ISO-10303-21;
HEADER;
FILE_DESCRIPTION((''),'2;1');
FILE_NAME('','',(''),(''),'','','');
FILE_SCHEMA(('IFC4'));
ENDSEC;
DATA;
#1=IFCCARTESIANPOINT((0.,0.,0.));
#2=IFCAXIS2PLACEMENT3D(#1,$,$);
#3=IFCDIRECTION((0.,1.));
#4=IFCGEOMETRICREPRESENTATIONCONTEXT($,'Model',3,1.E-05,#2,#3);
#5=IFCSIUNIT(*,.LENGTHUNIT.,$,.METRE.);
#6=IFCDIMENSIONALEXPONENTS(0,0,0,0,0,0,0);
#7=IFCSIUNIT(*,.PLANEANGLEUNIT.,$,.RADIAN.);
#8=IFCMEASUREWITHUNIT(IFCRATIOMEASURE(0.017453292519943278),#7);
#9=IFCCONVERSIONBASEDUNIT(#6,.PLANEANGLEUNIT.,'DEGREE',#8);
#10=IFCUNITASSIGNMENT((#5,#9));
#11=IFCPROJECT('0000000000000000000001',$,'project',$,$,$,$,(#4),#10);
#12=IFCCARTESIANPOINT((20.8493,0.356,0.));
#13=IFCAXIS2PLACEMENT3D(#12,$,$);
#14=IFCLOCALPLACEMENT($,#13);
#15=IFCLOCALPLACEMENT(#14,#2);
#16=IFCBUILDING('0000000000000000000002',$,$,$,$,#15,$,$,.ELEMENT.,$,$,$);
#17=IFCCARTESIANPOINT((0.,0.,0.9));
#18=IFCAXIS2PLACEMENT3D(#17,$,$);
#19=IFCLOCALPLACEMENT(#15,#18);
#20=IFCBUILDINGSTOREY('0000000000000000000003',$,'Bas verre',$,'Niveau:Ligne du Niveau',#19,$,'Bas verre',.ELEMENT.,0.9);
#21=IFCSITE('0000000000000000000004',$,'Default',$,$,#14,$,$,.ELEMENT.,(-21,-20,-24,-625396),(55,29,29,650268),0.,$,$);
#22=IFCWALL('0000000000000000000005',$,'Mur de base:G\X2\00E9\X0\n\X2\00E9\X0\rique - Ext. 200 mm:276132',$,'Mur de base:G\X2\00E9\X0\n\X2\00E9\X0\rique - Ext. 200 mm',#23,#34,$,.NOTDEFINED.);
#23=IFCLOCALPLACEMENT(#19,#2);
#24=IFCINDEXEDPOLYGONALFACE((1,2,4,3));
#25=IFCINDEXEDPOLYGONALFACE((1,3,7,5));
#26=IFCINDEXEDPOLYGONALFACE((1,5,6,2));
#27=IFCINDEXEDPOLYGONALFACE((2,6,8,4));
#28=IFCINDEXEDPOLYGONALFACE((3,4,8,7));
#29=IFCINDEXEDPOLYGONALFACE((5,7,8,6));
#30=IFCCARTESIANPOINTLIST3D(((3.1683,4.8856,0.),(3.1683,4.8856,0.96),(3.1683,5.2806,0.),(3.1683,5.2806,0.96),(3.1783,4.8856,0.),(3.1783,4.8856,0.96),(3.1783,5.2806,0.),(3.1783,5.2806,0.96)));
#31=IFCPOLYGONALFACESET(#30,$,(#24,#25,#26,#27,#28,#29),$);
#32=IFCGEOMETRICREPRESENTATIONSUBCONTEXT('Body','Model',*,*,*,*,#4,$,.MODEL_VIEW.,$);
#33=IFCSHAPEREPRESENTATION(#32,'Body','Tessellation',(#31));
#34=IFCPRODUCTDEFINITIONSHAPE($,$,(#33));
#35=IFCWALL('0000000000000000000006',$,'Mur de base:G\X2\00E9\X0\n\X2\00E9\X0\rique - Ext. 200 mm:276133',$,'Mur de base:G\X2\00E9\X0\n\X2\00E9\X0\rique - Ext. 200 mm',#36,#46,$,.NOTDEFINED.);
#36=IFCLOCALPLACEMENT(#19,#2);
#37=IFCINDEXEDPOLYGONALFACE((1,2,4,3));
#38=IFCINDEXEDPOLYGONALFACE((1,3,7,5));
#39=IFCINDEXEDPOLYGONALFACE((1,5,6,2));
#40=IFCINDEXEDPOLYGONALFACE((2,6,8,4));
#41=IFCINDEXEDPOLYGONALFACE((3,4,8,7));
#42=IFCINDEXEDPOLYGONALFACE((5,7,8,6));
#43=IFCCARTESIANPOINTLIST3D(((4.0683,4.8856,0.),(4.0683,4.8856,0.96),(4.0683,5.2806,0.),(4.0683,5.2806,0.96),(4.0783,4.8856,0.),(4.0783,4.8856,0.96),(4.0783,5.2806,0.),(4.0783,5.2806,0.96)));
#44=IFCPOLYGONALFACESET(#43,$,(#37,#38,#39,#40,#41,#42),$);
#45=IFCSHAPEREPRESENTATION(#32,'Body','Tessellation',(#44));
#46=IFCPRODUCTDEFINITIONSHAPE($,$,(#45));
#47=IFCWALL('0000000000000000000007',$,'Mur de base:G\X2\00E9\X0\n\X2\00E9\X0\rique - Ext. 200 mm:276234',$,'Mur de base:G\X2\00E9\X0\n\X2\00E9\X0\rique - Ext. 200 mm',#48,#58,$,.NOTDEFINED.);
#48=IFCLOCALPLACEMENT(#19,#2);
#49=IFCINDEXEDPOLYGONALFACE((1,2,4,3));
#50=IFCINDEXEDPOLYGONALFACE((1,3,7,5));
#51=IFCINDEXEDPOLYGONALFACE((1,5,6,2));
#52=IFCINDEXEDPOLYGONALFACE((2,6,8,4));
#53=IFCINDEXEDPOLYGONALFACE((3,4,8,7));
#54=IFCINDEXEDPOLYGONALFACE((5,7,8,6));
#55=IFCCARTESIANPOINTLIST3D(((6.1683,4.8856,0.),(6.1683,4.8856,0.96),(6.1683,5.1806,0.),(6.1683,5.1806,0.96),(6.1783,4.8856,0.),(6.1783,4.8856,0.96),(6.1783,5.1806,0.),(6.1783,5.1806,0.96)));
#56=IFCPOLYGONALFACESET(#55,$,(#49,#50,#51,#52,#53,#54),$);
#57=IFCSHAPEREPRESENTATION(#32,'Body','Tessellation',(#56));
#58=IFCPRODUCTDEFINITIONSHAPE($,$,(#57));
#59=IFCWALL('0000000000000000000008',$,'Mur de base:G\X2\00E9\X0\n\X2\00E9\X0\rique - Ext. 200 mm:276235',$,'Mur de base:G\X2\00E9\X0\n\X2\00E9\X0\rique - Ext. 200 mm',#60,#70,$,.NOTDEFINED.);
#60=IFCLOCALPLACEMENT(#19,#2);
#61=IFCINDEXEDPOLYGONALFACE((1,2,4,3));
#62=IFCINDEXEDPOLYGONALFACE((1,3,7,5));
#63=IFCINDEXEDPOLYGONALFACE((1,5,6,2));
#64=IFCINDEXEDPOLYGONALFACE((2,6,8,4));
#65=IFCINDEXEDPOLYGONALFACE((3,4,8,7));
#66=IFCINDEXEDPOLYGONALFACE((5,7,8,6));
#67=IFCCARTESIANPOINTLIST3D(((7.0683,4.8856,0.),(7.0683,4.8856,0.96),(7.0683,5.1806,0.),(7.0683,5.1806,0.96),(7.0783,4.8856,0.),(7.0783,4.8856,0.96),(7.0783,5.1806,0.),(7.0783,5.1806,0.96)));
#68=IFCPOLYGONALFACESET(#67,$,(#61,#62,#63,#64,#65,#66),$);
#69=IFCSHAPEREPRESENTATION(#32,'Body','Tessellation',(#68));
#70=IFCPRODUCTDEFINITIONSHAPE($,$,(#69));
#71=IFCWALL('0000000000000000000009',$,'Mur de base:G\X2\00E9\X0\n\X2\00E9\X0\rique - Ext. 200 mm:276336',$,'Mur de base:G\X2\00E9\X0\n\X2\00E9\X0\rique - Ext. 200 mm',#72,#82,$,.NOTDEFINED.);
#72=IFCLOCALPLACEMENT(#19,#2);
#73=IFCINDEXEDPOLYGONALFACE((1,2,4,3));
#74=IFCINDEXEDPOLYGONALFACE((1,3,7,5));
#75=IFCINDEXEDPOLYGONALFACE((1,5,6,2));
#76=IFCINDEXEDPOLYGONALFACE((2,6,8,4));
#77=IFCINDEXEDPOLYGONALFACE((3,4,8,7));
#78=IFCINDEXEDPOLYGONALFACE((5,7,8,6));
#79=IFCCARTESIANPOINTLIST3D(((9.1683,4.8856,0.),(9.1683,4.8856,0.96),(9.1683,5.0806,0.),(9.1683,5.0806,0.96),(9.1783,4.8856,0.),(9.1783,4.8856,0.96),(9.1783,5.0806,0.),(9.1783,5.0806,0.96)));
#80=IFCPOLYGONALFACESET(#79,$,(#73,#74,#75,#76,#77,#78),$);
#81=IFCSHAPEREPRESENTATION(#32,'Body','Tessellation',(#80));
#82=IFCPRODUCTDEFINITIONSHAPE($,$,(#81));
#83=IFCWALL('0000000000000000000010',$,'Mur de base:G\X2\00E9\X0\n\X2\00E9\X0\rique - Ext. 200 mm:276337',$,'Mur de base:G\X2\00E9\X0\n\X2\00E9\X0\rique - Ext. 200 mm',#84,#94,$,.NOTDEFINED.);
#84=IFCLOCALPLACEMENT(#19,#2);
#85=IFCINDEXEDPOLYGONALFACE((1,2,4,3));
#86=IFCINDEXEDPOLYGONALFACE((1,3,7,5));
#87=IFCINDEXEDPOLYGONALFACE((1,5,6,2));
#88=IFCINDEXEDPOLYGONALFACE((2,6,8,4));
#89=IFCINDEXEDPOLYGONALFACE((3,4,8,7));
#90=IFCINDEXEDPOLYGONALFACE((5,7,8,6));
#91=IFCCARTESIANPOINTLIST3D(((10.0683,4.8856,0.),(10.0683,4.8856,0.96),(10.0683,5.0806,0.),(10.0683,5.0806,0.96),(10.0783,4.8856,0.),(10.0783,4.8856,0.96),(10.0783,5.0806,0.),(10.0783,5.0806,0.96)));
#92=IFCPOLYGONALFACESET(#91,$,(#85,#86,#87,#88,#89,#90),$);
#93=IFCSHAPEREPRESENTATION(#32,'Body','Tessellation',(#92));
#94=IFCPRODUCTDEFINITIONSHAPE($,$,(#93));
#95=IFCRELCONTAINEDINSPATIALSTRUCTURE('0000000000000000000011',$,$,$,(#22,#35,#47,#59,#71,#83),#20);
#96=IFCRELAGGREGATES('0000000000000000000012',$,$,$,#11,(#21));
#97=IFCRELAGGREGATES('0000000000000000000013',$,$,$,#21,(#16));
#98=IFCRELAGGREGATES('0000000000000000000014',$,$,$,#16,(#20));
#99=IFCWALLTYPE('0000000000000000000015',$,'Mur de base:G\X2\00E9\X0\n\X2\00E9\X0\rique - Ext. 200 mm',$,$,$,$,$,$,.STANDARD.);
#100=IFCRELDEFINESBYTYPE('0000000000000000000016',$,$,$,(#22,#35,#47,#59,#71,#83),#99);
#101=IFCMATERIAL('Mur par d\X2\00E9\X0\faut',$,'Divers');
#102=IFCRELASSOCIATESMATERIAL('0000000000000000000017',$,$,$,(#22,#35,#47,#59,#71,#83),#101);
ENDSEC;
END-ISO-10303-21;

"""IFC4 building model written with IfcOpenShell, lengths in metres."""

from ifc_helpers import new_model, entity, si_unit, converted_unit, direction, frame, origin, place, context, subcontext, project, spatial, indexed_curve, outline, extrude, material, type_object, element, save


model = new_model("IFC4")

# Units and contexts
model_context = context("Model", 3, precision=1e-05, world=origin(), true_north=direction((0.0, 1.0)))
body_context = subcontext(model_context, "Body", "Model", "MODEL_VIEW")
ifc_project = project(units=[si_unit("LENGTHUNIT", "METRE"), converted_unit("PLANEANGLEUNIT", "DEGREE", entity("IfcRatioMeasure", 0.017453292519943278), si_unit("PLANEANGLEUNIT", "RADIAN"), dimensions=[0, 0, 0, 0, 0, 0, 0])], contexts=[model_context])

# Site, building, storey
site_placement = place(None, frame((20.8493, 0.356, 0.0)))
site = spatial("IfcSite", under=ifc_project, at=site_placement, Name="Default", CompositionType="ELEMENT", RefLatitude=(-21, -20, -24, -625396), RefLongitude=(55, 29, 29, 650268), RefElevation=0.0)
building_placement = place(site_placement, origin())
building = spatial("IfcBuilding", under=site, at=building_placement, CompositionType="ELEMENT")
storey_placement = place(building_placement, frame((0.0, 0.0, 0.9)))
storey = spatial("IfcBuildingStorey", under=building, at=storey_placement, Name="Bas verre", ObjectType="Niveau:Ligne du Niveau", LongName="Bas verre", CompositionType="ELEMENT", Elevation=0.9)

# Walls
ifc_material = material(Name="Mur par défaut", Category="Divers")
wall_type = type_object("IfcWallType", Name="Mur de base:Générique - Ext. 200 mm", PredefinedType="STANDARD")
wall_1_placement = place(storey_placement, frame((3.1733, 4.8856, 0.0), z_axis=(0.0, 0.0, 1.0), x_axis=(0.0, 1.0, 0.0)))
element("IfcWall", 1, at=wall_1_placement, inside=storey, type_object=wall_type, material=ifc_material, Name="Mur de base:Générique - Ext. 200 mm:276132", ObjectType="Mur de base:Générique - Ext. 200 mm", PredefinedType="NOTDEFINED", context=body_context, shape_type="SweptSolid", body=[
    extrude(outline(indexed_curve([(0.395, 0.005), (0.0, 0.005), (0.0, -0.005), (0.395, -0.005), (0.395, 0.005)], self_intersect=False)), origin(), (0.0, 0.0, 1.0), 0.96),
])
wall_2_placement = place(storey_placement, frame((4.0733, 4.8856, 0.0), z_axis=(0.0, 0.0, 1.0), x_axis=(0.0, 1.0, 0.0)))
element("IfcWall", 2, at=wall_2_placement, inside=storey, type_object=wall_type, material=ifc_material, Name="Mur de base:Générique - Ext. 200 mm:276133", ObjectType="Mur de base:Générique - Ext. 200 mm", PredefinedType="NOTDEFINED", context=body_context, shape_type="SweptSolid", body=[
    extrude(outline(indexed_curve([(0.395, 0.005), (0.0, 0.005), (0.0, -0.005), (0.395, -0.005), (0.395, 0.005)], self_intersect=False)), origin(), (0.0, 0.0, 1.0), 0.96),
])
wall_3_placement = place(storey_placement, frame((6.1733, 4.8856, 0.0), z_axis=(0.0, 0.0, 1.0), x_axis=(0.0, 1.0, 0.0)))
element("IfcWall", 3, at=wall_3_placement, inside=storey, type_object=wall_type, material=ifc_material, Name="Mur de base:Générique - Ext. 200 mm:276234", ObjectType="Mur de base:Générique - Ext. 200 mm", PredefinedType="NOTDEFINED", context=body_context, shape_type="SweptSolid", body=[
    extrude(outline(indexed_curve([(0.295, 0.005), (0.0, 0.005), (0.0, -0.005), (0.295, -0.005), (0.295, 0.005)], self_intersect=False)), origin(), (0.0, 0.0, 1.0), 0.96),
])
wall_4_placement = place(storey_placement, frame((7.0733, 4.8856, 0.0), z_axis=(0.0, 0.0, 1.0), x_axis=(0.0, 1.0, 0.0)))
element("IfcWall", 4, at=wall_4_placement, inside=storey, type_object=wall_type, material=ifc_material, Name="Mur de base:Générique - Ext. 200 mm:276235", ObjectType="Mur de base:Générique - Ext. 200 mm", PredefinedType="NOTDEFINED", context=body_context, shape_type="SweptSolid", body=[
    extrude(outline(indexed_curve([(0.295, 0.005), (0.0, 0.005), (0.0, -0.005), (0.295, -0.005), (0.295, 0.005)], self_intersect=False)), origin(), (0.0, 0.0, 1.0), 0.96),
])
wall_5_placement = place(storey_placement, frame((9.1733, 4.8856, 0.0), z_axis=(0.0, 0.0, 1.0), x_axis=(0.0, 1.0, 0.0)))
element("IfcWall", 5, at=wall_5_placement, inside=storey, type_object=wall_type, material=ifc_material, Name="Mur de base:Générique - Ext. 200 mm:276336", ObjectType="Mur de base:Générique - Ext. 200 mm", PredefinedType="NOTDEFINED", context=body_context, shape_type="SweptSolid", body=[
    extrude(outline(indexed_curve([(0.195, 0.005), (0.0, 0.005), (0.0, -0.005), (0.195, -0.005), (0.195, 0.005)], self_intersect=False)), origin(), (0.0, 0.0, 1.0), 0.96),
])
wall_6_placement = place(storey_placement, frame((10.0733, 4.8856, 0.0), z_axis=(0.0, 0.0, 1.0), x_axis=(0.0, 1.0, 0.0)))
element("IfcWall", 6, at=wall_6_placement, inside=storey, type_object=wall_type, material=ifc_material, Name="Mur de base:Générique - Ext. 200 mm:276337", ObjectType="Mur de base:Générique - Ext. 200 mm", PredefinedType="NOTDEFINED", context=body_context, shape_type="SweptSolid", body=[
    extrude(outline(indexed_curve([(0.195, 0.005), (0.0, 0.005), (0.0, -0.005), (0.195, -0.005), (0.195, 0.005)], self_intersect=False)), origin(), (0.0, 0.0, 1.0), 0.96),
])

save(model, "model.ifc")
